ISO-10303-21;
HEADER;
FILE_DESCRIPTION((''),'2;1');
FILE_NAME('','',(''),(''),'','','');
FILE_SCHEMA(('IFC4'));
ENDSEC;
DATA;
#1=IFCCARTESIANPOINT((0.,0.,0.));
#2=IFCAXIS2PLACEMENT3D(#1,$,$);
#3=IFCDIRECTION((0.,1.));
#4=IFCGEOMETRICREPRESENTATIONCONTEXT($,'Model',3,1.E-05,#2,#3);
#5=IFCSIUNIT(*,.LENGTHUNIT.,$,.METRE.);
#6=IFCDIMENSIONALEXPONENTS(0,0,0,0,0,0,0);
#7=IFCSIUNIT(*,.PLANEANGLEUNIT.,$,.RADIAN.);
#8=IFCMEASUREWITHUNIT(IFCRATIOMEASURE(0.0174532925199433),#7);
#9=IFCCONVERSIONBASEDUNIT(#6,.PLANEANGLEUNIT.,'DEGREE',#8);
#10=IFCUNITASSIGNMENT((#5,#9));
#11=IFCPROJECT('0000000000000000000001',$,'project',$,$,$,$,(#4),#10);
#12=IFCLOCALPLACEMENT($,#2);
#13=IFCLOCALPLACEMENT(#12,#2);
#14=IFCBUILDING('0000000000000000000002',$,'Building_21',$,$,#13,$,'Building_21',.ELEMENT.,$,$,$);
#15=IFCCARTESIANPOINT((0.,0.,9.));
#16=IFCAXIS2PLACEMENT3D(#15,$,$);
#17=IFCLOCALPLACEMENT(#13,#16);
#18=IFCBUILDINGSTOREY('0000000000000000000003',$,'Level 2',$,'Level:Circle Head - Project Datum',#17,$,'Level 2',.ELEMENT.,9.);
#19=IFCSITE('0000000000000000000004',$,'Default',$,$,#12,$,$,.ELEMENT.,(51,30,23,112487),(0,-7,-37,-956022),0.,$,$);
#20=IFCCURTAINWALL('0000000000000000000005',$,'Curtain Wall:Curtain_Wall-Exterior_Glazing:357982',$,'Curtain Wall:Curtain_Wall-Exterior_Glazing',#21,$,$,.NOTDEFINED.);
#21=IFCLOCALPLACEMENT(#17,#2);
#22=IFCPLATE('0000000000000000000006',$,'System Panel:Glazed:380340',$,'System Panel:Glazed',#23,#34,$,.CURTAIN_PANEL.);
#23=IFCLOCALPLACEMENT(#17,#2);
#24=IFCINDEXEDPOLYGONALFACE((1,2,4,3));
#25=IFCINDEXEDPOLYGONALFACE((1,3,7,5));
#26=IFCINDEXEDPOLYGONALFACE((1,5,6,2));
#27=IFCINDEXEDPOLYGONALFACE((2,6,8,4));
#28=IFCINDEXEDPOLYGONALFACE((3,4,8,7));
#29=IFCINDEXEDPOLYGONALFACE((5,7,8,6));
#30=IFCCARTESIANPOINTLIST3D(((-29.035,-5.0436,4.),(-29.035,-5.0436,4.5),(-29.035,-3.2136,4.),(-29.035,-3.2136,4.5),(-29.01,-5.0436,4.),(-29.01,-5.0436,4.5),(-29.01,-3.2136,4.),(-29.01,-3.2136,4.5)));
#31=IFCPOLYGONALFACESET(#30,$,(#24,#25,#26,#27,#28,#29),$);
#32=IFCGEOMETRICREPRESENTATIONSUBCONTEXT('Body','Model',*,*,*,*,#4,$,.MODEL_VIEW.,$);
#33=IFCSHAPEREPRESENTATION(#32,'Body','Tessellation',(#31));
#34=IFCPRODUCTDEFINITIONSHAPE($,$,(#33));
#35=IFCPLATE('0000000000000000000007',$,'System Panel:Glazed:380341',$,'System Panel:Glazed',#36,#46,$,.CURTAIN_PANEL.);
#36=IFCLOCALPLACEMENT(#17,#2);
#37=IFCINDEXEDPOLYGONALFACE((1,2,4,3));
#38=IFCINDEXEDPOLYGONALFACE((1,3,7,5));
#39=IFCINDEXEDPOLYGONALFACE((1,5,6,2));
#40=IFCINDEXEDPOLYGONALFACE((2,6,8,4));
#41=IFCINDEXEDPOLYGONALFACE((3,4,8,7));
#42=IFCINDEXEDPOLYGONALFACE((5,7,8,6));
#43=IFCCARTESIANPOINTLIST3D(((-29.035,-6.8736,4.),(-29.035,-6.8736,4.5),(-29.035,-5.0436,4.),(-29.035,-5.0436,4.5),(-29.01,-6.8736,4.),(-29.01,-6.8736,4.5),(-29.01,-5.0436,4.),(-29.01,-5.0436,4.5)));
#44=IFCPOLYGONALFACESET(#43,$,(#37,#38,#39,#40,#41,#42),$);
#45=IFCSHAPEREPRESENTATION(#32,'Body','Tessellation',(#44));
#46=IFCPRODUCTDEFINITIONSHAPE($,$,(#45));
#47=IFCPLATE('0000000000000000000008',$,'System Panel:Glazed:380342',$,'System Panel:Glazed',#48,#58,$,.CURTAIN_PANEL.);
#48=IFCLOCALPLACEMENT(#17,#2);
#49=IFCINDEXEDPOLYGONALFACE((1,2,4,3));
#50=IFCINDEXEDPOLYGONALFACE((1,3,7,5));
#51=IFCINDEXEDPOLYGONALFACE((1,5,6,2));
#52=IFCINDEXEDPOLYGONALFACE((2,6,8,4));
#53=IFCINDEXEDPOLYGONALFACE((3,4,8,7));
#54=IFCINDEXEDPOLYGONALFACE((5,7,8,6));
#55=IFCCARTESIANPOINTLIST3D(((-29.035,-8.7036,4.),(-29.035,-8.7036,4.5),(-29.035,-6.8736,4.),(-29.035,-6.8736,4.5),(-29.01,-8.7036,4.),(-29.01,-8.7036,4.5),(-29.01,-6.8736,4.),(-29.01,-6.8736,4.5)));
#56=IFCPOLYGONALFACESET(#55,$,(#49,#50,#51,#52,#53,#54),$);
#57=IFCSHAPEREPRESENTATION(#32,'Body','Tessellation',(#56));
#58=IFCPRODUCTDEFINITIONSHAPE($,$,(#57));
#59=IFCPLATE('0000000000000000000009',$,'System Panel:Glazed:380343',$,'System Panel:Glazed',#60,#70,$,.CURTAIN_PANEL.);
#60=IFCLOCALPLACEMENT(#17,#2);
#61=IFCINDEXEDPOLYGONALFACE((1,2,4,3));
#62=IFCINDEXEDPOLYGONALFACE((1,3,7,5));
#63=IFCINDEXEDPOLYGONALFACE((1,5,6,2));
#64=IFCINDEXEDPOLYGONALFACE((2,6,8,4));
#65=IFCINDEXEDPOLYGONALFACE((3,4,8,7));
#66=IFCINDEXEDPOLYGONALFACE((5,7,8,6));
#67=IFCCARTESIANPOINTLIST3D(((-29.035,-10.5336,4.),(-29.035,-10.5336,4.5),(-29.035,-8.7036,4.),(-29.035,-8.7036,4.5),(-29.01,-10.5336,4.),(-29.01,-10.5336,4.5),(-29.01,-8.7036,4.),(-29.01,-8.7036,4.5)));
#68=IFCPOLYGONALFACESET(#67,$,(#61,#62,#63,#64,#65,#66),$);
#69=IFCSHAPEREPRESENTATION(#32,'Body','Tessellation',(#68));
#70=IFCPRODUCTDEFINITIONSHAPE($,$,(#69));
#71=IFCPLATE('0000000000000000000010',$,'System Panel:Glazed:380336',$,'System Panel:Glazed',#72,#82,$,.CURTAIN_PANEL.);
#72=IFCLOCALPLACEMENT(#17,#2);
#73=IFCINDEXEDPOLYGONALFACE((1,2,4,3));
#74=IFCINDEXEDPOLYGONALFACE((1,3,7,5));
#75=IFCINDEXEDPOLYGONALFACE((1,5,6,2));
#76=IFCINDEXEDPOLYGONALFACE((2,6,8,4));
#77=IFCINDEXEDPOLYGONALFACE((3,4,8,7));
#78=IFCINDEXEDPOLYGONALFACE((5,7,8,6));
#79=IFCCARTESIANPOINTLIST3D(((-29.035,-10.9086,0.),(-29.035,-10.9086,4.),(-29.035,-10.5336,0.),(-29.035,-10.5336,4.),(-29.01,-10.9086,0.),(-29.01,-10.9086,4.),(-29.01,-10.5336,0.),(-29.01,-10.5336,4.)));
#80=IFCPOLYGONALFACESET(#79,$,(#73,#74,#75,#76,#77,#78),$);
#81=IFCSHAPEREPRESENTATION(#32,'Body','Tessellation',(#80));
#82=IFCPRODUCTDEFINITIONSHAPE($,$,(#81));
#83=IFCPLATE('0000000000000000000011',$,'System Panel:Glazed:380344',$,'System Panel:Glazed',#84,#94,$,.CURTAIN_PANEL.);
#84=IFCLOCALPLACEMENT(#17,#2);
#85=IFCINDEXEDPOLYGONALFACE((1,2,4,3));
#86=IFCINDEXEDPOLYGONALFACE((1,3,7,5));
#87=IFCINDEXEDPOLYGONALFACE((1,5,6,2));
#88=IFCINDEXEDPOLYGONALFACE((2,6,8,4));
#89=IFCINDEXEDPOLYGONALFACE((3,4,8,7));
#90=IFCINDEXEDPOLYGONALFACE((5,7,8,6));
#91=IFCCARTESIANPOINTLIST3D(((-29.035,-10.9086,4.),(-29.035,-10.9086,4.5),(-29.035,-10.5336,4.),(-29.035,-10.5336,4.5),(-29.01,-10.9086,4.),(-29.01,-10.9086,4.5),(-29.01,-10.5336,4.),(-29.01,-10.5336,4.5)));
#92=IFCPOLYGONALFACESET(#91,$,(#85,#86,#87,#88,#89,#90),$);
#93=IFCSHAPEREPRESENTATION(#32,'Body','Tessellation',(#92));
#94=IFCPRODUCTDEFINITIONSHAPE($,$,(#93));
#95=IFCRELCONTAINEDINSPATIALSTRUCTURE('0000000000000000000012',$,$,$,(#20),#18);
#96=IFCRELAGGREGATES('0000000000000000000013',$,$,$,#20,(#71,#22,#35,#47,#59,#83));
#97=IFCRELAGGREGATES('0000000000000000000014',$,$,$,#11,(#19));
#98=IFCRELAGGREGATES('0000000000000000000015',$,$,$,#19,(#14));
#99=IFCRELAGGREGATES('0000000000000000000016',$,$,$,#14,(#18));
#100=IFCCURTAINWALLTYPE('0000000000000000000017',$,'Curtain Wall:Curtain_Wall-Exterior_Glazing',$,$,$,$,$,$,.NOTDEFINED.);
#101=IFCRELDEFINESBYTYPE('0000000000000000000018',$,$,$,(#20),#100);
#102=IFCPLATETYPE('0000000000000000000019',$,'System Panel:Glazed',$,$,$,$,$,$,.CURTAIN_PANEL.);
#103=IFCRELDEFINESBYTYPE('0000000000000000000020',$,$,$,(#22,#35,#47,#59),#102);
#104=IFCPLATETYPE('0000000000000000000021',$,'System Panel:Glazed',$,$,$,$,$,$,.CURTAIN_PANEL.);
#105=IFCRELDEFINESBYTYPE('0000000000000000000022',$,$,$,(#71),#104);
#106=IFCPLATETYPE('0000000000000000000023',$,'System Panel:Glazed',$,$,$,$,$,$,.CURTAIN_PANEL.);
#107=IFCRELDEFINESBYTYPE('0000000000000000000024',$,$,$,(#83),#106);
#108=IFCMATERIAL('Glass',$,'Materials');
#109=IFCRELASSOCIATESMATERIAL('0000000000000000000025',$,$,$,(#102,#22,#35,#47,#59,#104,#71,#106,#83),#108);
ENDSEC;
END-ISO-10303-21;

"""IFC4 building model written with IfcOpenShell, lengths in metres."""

from ifc_helpers import new_model, entity, si_unit, converted_unit, direction, frame, origin, origin_2d_with_axis, place, context, subcontext, project, spatial, rectangle, extrude, source, transform, mapped, material, type_object, type_shapes, element, aggregate, save


model = new_model("IFC4")

# Units and contexts
model_context = context("Model", 3, precision=1e-05, world=origin(), true_north=direction((0.0, 1.0)))
body_context = subcontext(model_context, "Body", "Model", "MODEL_VIEW")
ifc_project = project(units=[si_unit("LENGTHUNIT", "METRE"), converted_unit("PLANEANGLEUNIT", "DEGREE", entity("IfcRatioMeasure", 0.0174532925199433), si_unit("PLANEANGLEUNIT", "RADIAN"), dimensions=[0, 0, 0, 0, 0, 0, 0])], contexts=[model_context])

# Site, building, storey
site_placement = place(None, origin())
site = spatial("IfcSite", under=ifc_project, at=site_placement, Name="Default", CompositionType="ELEMENT", RefLatitude=(51, 30, 23, 112487), RefLongitude=(0, -7, -37, -956022), RefElevation=0.0)
building_placement = place(site_placement, origin())
building = spatial("IfcBuilding", under=site, at=building_placement, Name="Building_21", LongName="Building_21", CompositionType="ELEMENT")
storey_placement = place(building_placement, frame((0.0, 0.0, 9.0)))
storey = spatial("IfcBuildingStorey", under=building, at=storey_placement, Name="Level 2", ObjectType="Level:Circle Head - Project Datum", LongName="Level 2", CompositionType="ELEMENT", Elevation=9.0)

# Curtain wall, plates
curtain_wall_type = type_object("IfcCurtainWallType", Name="Curtain Wall:Curtain_Wall-Exterior_Glazing", PredefinedType="NOTDEFINED")
curtain_wall_placement = place(storey_placement, frame((0.0, 0.0, -9.0)))
curtain_wall = element("IfcCurtainWall", 1, at=curtain_wall_placement, inside=storey, type_object=curtain_wall_type, Name="Curtain Wall:Curtain_Wall-Exterior_Glazing:357982", ObjectType="Curtain Wall:Curtain_Wall-Exterior_Glazing", PredefinedType="NOTDEFINED")
ifc_material_1 = material(Name="Glass", Category="Materials")
plate_type_1 = type_object("IfcPlateType", Name="System Panel:Glazed", PredefinedType="CURTAIN_PANEL", material=ifc_material_1)
shared_shape_1 = source(origin(), body_context, "Body", "SweptSolid", [
    extrude(rectangle(XDim=0.025, YDim=1.83, at=origin_2d_with_axis()), frame((0.915, 0.0125, 0.0), z_axis=(0.0, 0.0, 1.0), x_axis=(0.0, 1.0, 0.0)), (0.0, 0.0, 1.0), 0.5),
])
type_shapes(plate_type_1, [shared_shape_1])
plate_1_placement = place(curtain_wall_placement, frame((-29.035, -3.2136, 13.0), z_axis=(0.0, 0.0, 1.0), x_axis=(0.0, -1.0, 0.0)))
plate_1 = element("IfcPlate", 2, at=plate_1_placement, type_object=plate_type_1, material=ifc_material_1, Name="System Panel:Glazed:380340", ObjectType="System Panel:Glazed", PredefinedType="CURTAIN_PANEL", context=body_context, shape_type="MappedRepresentation", body=[
    mapped(shared_shape_1, transform((0.0, 0.0, 0.0), scale=1.0)),
])
plate_2_placement = place(curtain_wall_placement, frame((-29.035, -5.0436, 13.0), z_axis=(0.0, 0.0, 1.0), x_axis=(0.0, -1.0, 0.0)))
plate_2 = element("IfcPlate", 3, at=plate_2_placement, type_object=plate_type_1, material=ifc_material_1, Name="System Panel:Glazed:380341", ObjectType="System Panel:Glazed", PredefinedType="CURTAIN_PANEL", context=body_context, shape_type="MappedRepresentation", body=[
    mapped(shared_shape_1, transform((0.0, 0.0, 0.0), scale=1.0)),
])
plate_3_placement = place(curtain_wall_placement, frame((-29.035, -6.8736, 13.0), z_axis=(0.0, 0.0, 1.0), x_axis=(0.0, -1.0, 0.0)))
plate_3 = element("IfcPlate", 4, at=plate_3_placement, type_object=plate_type_1, material=ifc_material_1, Name="System Panel:Glazed:380342", ObjectType="System Panel:Glazed", PredefinedType="CURTAIN_PANEL", context=body_context, shape_type="MappedRepresentation", body=[
    mapped(shared_shape_1, transform((0.0, 0.0, 0.0), scale=1.0)),
])
plate_4_placement = place(curtain_wall_placement, frame((-29.035, -8.7036, 13.0), z_axis=(0.0, 0.0, 1.0), x_axis=(0.0, -1.0, 0.0)))
plate_4 = element("IfcPlate", 5, at=plate_4_placement, type_object=plate_type_1, material=ifc_material_1, Name="System Panel:Glazed:380343", ObjectType="System Panel:Glazed", PredefinedType="CURTAIN_PANEL", context=body_context, shape_type="MappedRepresentation", body=[
    mapped(shared_shape_1, transform((0.0, 0.0, 0.0), scale=1.0)),
])
plate_type_2 = type_object("IfcPlateType", Name="System Panel:Glazed", PredefinedType="CURTAIN_PANEL", material=ifc_material_1)
shared_shape_2 = source(origin(), body_context, "Body", "SweptSolid", [
    extrude(rectangle(XDim=0.025, YDim=0.375, at=origin_2d_with_axis()), frame((0.1875, 0.0125, 0.0), z_axis=(0.0, 0.0, 1.0), x_axis=(0.0, 1.0, 0.0)), (0.0, 0.0, 1.0), 4.0),
])
type_shapes(plate_type_2, [shared_shape_2])
plate_5_placement = place(curtain_wall_placement, frame((-29.035, -10.5336, 9.0), z_axis=(0.0, 0.0, 1.0), x_axis=(0.0, -1.0, 0.0)))
plate_5 = element("IfcPlate", 6, at=plate_5_placement, type_object=plate_type_2, material=ifc_material_1, Name="System Panel:Glazed:380336", ObjectType="System Panel:Glazed", PredefinedType="CURTAIN_PANEL", context=body_context, shape_type="MappedRepresentation", body=[
    mapped(shared_shape_2, transform((0.0, 0.0, 0.0), scale=1.0)),
])
plate_type_3 = type_object("IfcPlateType", Name="System Panel:Glazed", PredefinedType="CURTAIN_PANEL", material=ifc_material_1)
shared_shape_3 = source(origin(), body_context, "Body", "SweptSolid", [
    extrude(rectangle(XDim=0.025, YDim=0.375, at=origin_2d_with_axis()), frame((0.1875, 0.0125, 0.0), z_axis=(0.0, 0.0, 1.0), x_axis=(0.0, 1.0, 0.0)), (0.0, 0.0, 1.0), 0.5),
])
type_shapes(plate_type_3, [shared_shape_3])
plate_6_placement = place(curtain_wall_placement, frame((-29.035, -10.5336, 13.0), z_axis=(0.0, 0.0, 1.0), x_axis=(0.0, -1.0, 0.0)))
plate_6 = element("IfcPlate", 7, at=plate_6_placement, type_object=plate_type_3, material=ifc_material_1, Name="System Panel:Glazed:380344", ObjectType="System Panel:Glazed", PredefinedType="CURTAIN_PANEL", context=body_context, shape_type="MappedRepresentation", body=[
    mapped(shared_shape_3, transform((0.0, 0.0, 0.0), scale=1.0)),
])
aggregate(curtain_wall, [plate_5, plate_1, plate_2, plate_3, plate_4, plate_6])

save(model, "model.ifc")
